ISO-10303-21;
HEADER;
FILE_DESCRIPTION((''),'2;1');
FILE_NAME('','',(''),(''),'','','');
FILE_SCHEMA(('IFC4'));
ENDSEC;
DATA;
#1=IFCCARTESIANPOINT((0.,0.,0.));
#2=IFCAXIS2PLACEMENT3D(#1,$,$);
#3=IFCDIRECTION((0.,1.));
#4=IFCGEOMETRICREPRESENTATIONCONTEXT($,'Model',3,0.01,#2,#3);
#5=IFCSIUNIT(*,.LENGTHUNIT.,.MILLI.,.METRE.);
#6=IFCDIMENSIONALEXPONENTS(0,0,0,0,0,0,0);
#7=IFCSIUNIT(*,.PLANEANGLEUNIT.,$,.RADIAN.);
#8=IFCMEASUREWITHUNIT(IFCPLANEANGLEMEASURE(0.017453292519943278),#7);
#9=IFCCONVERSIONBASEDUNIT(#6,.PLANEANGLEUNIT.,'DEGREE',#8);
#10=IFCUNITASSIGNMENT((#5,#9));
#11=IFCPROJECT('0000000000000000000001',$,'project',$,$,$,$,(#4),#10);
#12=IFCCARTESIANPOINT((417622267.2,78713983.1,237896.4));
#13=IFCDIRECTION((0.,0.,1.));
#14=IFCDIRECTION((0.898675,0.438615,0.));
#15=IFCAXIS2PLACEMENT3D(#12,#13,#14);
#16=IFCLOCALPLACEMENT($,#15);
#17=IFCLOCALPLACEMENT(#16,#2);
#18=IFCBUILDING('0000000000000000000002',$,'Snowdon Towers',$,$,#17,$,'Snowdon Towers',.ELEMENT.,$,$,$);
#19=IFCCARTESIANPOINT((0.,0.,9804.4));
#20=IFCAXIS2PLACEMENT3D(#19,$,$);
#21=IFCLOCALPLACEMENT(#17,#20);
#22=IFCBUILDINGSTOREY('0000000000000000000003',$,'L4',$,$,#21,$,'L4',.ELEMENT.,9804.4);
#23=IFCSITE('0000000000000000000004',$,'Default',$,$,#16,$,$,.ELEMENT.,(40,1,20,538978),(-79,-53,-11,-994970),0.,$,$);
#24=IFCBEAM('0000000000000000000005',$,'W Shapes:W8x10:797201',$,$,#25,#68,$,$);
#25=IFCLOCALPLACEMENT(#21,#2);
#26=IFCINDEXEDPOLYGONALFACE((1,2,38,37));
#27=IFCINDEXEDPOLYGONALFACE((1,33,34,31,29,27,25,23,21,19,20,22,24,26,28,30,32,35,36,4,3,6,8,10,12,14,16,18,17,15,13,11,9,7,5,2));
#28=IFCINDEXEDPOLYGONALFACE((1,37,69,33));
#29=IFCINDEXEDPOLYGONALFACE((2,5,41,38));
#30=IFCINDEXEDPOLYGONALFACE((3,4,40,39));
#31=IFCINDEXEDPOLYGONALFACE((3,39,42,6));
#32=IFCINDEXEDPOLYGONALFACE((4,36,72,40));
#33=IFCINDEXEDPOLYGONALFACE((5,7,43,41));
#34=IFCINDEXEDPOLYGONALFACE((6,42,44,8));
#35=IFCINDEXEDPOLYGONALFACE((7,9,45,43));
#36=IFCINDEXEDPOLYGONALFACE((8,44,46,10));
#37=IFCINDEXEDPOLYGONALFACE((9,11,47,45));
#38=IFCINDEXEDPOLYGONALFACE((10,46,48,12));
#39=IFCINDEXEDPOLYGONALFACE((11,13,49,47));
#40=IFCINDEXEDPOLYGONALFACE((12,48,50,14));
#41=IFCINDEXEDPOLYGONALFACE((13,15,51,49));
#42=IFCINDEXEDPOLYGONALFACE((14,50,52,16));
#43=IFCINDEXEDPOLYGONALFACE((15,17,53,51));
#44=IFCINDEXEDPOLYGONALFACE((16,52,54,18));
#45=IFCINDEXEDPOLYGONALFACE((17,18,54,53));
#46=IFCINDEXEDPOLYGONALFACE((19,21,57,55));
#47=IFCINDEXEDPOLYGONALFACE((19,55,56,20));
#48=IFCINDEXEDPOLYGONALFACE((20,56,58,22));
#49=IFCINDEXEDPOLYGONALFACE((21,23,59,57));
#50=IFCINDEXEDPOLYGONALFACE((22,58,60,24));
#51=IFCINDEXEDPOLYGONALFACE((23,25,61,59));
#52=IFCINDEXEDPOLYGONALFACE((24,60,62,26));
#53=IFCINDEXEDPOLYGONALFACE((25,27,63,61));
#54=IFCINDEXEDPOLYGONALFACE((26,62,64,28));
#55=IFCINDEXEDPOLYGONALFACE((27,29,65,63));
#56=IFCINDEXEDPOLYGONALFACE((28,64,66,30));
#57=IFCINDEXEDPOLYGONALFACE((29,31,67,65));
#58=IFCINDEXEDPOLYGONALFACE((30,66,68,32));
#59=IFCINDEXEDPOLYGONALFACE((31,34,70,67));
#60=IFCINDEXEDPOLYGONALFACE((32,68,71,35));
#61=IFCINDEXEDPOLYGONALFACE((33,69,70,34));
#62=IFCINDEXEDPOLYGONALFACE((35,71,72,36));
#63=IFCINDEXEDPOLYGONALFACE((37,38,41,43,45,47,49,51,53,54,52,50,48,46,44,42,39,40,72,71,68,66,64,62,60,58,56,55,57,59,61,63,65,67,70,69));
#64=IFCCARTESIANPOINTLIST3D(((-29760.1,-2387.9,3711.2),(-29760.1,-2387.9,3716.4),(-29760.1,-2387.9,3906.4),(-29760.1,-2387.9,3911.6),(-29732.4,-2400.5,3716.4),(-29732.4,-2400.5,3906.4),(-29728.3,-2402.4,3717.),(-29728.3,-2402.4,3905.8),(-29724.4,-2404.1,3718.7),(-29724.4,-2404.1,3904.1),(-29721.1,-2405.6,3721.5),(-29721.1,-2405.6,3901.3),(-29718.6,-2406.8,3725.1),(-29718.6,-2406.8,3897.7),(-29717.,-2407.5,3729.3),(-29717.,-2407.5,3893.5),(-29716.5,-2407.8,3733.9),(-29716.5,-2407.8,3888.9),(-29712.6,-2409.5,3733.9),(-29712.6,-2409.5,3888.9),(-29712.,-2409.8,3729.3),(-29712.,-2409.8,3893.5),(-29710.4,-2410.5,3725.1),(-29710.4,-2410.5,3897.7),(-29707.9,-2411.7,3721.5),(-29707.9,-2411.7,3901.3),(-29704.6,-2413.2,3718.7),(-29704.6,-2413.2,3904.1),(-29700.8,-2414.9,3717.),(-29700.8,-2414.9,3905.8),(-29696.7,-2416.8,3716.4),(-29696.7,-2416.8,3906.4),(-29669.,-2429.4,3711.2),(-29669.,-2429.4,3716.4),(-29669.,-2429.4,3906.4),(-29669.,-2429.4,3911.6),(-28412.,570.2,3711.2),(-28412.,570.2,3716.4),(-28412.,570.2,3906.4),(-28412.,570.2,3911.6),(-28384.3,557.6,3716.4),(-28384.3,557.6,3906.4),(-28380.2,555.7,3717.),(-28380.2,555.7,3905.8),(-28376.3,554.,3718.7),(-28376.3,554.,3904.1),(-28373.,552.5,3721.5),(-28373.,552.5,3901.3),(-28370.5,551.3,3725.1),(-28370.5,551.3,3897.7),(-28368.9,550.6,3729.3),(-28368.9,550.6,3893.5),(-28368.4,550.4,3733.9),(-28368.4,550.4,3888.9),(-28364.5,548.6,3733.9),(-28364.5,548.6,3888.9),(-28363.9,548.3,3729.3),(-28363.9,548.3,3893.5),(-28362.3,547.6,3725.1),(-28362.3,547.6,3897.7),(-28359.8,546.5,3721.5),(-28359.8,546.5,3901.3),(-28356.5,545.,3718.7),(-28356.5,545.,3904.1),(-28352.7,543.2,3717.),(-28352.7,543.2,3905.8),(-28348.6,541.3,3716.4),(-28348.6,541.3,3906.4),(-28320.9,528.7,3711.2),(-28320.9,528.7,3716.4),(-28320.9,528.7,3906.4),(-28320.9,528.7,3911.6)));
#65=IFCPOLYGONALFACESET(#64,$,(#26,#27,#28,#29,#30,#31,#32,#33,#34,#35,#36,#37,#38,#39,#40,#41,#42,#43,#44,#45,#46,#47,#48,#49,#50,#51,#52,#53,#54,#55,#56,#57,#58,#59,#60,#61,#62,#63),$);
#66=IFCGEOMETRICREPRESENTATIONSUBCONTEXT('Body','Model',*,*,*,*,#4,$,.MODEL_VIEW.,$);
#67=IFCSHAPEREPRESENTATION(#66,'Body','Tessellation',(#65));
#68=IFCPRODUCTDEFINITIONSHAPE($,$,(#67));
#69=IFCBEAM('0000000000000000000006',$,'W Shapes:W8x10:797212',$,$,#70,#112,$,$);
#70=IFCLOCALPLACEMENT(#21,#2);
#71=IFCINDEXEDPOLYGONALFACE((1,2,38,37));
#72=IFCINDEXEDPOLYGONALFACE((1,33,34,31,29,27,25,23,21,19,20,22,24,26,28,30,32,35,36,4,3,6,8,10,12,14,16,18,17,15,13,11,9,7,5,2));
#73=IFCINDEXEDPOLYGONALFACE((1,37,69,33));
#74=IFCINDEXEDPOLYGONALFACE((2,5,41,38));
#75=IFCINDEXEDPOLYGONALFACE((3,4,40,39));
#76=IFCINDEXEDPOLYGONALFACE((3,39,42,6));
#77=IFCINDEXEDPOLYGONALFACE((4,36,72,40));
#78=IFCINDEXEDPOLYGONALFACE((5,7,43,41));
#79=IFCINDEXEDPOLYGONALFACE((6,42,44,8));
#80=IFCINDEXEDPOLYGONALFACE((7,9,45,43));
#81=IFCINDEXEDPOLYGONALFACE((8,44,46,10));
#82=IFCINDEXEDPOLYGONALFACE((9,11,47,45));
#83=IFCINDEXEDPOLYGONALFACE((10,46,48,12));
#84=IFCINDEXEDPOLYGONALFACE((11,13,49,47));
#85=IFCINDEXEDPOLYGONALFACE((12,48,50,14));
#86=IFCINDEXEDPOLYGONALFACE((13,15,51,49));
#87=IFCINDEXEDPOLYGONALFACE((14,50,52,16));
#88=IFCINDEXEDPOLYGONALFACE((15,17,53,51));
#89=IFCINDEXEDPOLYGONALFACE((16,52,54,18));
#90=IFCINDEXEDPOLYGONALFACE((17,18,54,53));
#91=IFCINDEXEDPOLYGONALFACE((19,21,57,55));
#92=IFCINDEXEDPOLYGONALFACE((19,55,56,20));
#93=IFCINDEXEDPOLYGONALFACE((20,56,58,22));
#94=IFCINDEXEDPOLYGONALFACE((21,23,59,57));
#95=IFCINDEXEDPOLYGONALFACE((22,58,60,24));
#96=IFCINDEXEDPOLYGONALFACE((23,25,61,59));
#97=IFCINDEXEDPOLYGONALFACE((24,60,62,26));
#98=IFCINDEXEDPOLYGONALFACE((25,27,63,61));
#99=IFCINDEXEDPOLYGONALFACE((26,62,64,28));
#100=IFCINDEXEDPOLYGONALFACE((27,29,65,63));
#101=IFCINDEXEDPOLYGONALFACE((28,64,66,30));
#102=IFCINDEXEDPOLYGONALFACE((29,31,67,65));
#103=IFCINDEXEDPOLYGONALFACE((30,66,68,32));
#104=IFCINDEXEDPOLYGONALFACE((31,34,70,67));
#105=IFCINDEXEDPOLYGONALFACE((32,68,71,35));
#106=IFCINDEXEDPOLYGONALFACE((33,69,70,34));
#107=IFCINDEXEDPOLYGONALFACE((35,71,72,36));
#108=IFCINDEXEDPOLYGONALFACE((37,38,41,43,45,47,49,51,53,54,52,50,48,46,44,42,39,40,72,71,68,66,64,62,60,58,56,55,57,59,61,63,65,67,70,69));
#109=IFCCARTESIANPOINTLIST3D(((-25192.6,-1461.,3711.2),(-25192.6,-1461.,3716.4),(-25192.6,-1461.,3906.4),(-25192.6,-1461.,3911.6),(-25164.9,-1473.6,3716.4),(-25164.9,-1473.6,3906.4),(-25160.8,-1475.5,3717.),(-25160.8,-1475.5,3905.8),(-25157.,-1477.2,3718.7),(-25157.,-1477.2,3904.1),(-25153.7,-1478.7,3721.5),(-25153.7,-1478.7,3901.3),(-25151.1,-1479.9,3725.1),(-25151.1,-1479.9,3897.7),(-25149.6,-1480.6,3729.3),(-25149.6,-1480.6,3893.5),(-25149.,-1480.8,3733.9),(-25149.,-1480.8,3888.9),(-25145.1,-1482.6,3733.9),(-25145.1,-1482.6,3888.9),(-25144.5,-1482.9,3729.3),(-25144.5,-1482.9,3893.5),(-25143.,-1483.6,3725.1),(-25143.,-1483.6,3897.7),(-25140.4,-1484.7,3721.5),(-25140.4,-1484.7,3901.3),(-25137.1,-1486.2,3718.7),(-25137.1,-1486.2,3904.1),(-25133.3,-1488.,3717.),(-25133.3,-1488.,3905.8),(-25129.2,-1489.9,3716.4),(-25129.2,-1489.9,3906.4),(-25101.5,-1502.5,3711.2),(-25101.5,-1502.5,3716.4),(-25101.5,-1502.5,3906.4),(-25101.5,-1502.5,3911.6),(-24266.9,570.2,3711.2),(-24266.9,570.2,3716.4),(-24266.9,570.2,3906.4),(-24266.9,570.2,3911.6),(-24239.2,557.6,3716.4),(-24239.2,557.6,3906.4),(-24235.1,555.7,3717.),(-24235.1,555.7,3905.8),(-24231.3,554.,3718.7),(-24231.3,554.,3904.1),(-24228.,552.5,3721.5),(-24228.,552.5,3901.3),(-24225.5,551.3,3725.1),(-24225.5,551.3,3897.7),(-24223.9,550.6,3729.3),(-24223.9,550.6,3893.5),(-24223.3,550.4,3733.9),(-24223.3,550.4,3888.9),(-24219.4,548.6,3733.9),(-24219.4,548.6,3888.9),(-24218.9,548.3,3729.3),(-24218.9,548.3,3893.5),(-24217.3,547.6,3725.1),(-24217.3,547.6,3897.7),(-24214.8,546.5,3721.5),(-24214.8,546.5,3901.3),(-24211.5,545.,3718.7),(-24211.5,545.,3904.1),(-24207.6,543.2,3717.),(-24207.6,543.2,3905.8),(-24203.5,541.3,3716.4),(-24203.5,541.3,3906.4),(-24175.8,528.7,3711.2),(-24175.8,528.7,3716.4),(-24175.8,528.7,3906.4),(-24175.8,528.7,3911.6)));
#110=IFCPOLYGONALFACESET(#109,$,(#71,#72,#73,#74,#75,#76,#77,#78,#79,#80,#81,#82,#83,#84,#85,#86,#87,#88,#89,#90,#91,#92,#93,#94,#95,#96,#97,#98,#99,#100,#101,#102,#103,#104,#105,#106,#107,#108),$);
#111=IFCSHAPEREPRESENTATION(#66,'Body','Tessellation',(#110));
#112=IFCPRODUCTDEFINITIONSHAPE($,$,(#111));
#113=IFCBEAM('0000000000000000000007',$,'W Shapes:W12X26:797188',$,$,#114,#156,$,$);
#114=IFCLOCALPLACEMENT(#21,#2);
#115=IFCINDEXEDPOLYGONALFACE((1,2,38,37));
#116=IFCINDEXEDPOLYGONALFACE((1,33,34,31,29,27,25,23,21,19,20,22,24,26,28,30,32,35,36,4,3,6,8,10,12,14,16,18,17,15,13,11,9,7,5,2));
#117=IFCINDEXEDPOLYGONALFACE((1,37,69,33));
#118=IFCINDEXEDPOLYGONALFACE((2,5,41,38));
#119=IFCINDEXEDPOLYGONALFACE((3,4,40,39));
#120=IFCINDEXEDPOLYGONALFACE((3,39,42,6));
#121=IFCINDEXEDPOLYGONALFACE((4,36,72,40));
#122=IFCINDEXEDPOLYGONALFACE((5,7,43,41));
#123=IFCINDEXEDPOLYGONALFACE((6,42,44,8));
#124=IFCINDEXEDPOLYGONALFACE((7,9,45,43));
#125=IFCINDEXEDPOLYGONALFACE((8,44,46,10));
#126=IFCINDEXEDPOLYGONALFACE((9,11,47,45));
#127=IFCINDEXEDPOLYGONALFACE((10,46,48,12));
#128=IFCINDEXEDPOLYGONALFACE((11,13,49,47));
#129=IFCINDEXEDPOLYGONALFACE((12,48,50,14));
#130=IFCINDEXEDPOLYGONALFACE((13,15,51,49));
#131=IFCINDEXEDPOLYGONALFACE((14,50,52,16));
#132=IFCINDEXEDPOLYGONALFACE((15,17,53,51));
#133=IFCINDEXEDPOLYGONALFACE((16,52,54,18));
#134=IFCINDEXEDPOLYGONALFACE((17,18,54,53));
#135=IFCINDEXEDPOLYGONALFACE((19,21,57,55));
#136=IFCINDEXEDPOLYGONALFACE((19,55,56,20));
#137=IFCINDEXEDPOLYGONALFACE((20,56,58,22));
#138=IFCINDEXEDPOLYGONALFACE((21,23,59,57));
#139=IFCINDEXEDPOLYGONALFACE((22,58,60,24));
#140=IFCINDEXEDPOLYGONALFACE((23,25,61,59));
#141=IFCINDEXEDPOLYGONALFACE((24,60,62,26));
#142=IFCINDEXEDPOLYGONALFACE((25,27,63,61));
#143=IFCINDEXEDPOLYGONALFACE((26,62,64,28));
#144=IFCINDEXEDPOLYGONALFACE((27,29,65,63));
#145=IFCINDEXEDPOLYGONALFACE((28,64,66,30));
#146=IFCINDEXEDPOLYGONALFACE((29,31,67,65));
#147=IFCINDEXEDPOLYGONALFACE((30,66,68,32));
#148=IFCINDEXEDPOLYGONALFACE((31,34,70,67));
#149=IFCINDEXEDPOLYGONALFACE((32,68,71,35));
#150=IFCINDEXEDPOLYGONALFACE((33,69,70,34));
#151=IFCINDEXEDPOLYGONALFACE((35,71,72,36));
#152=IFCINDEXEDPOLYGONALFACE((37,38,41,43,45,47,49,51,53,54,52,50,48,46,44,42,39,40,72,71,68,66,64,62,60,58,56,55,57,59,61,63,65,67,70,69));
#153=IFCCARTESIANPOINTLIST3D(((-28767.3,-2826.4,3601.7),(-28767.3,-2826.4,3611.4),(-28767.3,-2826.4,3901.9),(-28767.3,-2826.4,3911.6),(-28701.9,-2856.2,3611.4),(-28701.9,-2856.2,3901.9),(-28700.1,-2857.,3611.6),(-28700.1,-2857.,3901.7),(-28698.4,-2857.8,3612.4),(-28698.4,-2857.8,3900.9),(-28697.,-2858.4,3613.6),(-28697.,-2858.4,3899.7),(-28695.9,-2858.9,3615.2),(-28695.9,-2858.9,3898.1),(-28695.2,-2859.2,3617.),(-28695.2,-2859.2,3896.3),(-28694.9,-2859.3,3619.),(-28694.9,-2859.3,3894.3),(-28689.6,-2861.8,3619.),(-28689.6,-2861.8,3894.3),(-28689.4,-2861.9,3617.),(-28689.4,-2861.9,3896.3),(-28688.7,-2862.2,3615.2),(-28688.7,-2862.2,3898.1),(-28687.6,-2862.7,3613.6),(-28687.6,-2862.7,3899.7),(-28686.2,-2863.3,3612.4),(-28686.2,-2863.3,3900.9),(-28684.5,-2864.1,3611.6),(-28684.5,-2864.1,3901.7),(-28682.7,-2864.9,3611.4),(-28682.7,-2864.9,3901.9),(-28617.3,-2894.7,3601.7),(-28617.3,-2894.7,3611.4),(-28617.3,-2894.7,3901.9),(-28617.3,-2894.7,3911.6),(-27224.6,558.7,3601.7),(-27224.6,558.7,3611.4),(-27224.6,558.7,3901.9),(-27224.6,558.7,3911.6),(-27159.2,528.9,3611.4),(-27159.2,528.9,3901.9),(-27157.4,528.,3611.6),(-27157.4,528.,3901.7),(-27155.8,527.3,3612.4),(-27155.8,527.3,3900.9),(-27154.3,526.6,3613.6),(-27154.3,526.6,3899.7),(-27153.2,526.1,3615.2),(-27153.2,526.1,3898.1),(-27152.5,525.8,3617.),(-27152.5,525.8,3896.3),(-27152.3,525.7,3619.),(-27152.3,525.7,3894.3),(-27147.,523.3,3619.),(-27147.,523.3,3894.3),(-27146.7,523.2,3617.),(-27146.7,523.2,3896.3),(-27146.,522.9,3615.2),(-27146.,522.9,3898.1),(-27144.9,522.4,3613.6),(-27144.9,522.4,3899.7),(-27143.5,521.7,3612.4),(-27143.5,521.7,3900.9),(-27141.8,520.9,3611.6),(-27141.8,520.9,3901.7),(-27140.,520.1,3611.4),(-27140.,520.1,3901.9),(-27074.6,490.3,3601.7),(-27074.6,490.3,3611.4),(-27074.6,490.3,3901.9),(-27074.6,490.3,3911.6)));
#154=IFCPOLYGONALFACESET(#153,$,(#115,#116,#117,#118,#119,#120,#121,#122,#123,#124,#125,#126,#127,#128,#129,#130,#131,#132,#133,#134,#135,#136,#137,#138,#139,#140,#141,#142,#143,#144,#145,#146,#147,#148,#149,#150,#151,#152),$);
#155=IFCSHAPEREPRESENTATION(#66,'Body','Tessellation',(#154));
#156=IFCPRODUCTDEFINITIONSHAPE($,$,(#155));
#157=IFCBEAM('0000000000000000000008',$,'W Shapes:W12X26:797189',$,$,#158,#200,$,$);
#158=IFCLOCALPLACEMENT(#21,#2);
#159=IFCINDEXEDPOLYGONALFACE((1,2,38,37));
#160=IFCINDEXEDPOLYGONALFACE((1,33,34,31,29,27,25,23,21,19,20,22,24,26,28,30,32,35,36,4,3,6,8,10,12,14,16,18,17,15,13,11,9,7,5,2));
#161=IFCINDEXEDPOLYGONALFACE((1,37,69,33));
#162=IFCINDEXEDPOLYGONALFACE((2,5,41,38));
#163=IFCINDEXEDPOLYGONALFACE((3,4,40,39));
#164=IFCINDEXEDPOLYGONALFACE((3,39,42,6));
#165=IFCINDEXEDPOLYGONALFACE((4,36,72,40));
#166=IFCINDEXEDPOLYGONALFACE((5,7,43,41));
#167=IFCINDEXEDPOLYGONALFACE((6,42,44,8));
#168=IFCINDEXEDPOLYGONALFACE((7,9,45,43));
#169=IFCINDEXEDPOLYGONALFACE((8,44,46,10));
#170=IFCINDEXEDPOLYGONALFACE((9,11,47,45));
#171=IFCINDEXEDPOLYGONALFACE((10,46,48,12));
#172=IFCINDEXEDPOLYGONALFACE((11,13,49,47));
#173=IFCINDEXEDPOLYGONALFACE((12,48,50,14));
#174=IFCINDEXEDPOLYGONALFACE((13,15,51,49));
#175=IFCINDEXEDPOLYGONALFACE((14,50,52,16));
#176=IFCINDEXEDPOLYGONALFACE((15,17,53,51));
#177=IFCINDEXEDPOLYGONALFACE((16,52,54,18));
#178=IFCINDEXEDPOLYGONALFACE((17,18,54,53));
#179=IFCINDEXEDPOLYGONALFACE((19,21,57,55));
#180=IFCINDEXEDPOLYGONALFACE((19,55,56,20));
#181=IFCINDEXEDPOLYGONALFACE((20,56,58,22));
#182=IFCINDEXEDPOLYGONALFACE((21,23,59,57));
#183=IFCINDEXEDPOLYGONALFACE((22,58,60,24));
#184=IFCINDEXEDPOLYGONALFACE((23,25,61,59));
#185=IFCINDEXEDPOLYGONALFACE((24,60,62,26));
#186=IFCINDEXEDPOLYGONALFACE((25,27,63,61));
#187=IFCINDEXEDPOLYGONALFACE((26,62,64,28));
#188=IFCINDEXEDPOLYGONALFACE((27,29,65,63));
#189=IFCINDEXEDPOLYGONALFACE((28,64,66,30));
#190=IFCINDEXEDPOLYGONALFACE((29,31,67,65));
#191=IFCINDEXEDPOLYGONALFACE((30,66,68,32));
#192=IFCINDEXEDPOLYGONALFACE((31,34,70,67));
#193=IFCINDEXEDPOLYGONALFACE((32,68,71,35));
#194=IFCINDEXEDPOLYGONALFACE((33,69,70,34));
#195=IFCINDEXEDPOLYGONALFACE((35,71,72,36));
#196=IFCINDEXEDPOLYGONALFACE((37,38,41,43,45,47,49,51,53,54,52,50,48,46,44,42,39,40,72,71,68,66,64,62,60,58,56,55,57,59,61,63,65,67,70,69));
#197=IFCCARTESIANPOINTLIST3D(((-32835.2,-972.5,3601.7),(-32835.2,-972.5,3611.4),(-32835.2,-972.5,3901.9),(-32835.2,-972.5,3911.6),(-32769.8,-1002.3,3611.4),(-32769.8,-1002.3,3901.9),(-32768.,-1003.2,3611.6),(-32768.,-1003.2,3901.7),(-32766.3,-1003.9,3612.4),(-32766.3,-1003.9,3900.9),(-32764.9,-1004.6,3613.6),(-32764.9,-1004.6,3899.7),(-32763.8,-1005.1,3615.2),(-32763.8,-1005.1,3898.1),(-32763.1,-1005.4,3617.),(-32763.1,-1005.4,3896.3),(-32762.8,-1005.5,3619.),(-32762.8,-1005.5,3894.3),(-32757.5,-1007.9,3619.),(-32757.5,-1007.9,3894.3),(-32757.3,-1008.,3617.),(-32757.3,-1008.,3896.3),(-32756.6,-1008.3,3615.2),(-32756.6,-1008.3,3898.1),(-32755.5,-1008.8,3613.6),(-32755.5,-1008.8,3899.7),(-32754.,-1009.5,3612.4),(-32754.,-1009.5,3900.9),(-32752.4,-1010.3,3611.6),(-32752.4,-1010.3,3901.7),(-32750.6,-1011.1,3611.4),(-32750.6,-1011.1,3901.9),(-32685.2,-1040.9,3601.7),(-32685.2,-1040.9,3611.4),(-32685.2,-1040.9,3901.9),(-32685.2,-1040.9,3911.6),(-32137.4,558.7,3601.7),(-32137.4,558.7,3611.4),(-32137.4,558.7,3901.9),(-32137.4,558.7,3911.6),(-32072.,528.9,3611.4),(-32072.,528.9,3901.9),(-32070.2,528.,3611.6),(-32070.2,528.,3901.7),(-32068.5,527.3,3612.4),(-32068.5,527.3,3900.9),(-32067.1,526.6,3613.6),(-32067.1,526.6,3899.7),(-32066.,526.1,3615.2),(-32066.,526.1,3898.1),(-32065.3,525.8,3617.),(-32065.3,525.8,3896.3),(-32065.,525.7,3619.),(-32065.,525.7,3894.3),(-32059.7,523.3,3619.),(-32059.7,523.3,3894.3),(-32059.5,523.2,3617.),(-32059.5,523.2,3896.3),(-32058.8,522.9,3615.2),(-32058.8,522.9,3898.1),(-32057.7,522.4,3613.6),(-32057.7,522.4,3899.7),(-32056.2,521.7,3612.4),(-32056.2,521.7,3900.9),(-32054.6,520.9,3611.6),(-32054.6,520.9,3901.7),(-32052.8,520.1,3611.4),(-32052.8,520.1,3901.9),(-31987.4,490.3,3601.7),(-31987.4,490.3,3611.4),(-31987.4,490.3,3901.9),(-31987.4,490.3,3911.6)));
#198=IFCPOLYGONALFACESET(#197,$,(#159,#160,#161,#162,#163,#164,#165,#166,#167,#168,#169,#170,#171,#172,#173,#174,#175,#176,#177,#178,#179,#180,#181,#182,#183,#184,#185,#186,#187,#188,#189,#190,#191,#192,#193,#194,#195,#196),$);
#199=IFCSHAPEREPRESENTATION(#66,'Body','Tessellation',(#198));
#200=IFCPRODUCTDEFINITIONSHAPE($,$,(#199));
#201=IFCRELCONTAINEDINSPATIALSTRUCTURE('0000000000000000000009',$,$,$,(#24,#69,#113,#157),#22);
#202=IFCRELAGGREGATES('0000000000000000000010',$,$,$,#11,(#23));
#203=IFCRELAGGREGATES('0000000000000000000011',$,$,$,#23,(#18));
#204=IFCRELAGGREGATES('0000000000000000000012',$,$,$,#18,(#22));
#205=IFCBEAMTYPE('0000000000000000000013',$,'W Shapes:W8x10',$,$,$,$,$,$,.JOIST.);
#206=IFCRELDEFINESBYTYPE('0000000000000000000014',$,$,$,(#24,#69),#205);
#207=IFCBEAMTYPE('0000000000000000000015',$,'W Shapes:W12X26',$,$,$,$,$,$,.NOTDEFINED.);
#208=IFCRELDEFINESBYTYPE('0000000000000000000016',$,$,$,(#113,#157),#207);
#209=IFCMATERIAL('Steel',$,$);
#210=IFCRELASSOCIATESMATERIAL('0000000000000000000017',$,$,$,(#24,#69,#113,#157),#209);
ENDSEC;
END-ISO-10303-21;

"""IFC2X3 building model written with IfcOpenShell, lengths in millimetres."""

from ifc_helpers import new_model, entity, si_unit, converted_unit, direction, frame, frame_2d, origin, place, context, subcontext, project, spatial, i_section, extrude, material, type_object, element, save


model = new_model("IFC2X3")

# Units and contexts
model_context = context("Model", 3, precision=0.01, world=origin(), true_north=direction((0.0, 1.0)))
body_context = subcontext(model_context, "Body", "Model", "MODEL_VIEW")
ifc_project = project(units=[si_unit("LENGTHUNIT", "METRE", prefix="MILLI"), converted_unit("PLANEANGLEUNIT", "DEGREE", entity("IfcPlaneAngleMeasure", 0.017453292519943278), si_unit("PLANEANGLEUNIT", "RADIAN"), dimensions=[0, 0, 0, 0, 0, 0, 0])], contexts=[model_context])

# Site, building, storey
site_placement = place(None, frame((417622267.2, 78713983.1, 237896.4), z_axis=(0.0, 0.0, 1.0), x_axis=(0.898675, 0.438615, 0.0)))
site = spatial("IfcSite", under=ifc_project, at=site_placement, Name="Default", CompositionType="ELEMENT", RefLatitude=(40, 1, 20, 538978), RefLongitude=(-79, -53, -11, -994970), RefElevation=0.0)
building_placement = place(site_placement, origin())
building = spatial("IfcBuilding", under=site, at=building_placement, Name="Snowdon Towers", LongName="Snowdon Towers", CompositionType="ELEMENT")
storey_placement = place(building_placement, frame((0.0, 0.0, 9804.4)))
storey = spatial("IfcBuildingStorey", under=building, at=storey_placement, Name="L4", LongName="L4", CompositionType="ELEMENT", Elevation=9804.4)

# Shared definitions
ifc_material_1 = material(Name="Steel")

# Beams
beam_type_1 = type_object("IfcBeamType", Name="W Shapes:W8x10", PredefinedType="JOIST")
beam_1_placement = place(storey_placement, frame((-29748.7, -2483.6, 3911.6), z_axis=(0.0, 0.0, 1.0), x_axis=(0.414693, 0.909961, 0.0)))
element("IfcBeam", 1, at=beam_1_placement, inside=storey, type_object=beam_type_1, material=ifc_material_1, Name="W Shapes:W8x10:797201", context=body_context, shape_type="SweptSolid", body=[
    extrude(i_section(OverallWidth=100.1, OverallDepth=200.4, WebThickness=4.3, FlangeThickness=5.2, FilletRadius=17.5, at=frame_2d((0.0, 0.0), x_axis=(0.0, 1.0))), frame((82.4, 0.0, -100.2), z_axis=(1.0, 0.0, 0.0), x_axis=(0.0, 0.0, -1.0)), (0.0, 0.0, 1.0), 3250.8),
])
beam_2_placement = place(storey_placement, frame((-25181.2, -1556.7, 3911.6), z_axis=(0.0, 0.0, 1.0), x_axis=(0.414693, 0.909961, 0.0)))
element("IfcBeam", 2, at=beam_2_placement, inside=storey, type_object=beam_type_1, material=ifc_material_1, Name="W Shapes:W8x10:797212", context=body_context, shape_type="SweptSolid", body=[
    extrude(i_section(OverallWidth=100.1, OverallDepth=200.4, WebThickness=4.3, FlangeThickness=5.2, FilletRadius=17.5, at=frame_2d((0.0, 0.0), x_axis=(0.0, 1.0))), frame((82.4, 0.0, -100.2), z_axis=(1.0, 0.0, 0.0), x_axis=(0.0, 0.0, -1.0)), (0.0, 0.0, 1.0), 2232.2),
])
beam_type_2 = type_object("IfcBeamType", Name="W Shapes:W12X26", PredefinedType="NOTDEFINED")
beam_3_placement = place(storey_placement, frame((-28731.7, -2947.1, 3911.6), z_axis=(0.0, 0.0, 1.0), x_axis=(0.414693, 0.909961, 0.0)))
element("IfcBeam", 3, at=beam_3_placement, inside=storey, type_object=beam_type_2, material=ifc_material_1, Name="W Shapes:W12X26:797188", context=body_context, shape_type="SweptSolid", body=[
    extrude(i_section(OverallWidth=164.8, OverallDepth=309.9, WebThickness=5.8, FlangeThickness=9.7, FilletRadius=7.6, at=frame_2d((0.0, 0.0), x_axis=(0.0, 1.0))), frame((95.1, 0.0, -154.9), z_axis=(1.0, 0.0, 0.0), x_axis=(0.0, 0.0, -1.0)), (0.0, 0.0, 1.0), 3720.0),
])
beam_4_placement = place(storey_placement, frame((-32799.6, -1093.3, 3911.6), z_axis=(0.0, 0.0, 1.0), x_axis=(0.414693, 0.909961, 0.0)))
element("IfcBeam", 4, at=beam_4_placement, inside=storey, type_object=beam_type_2, material=ifc_material_1, Name="W Shapes:W12X26:797189", context=body_context, shape_type="SweptSolid", body=[
    extrude(i_section(OverallWidth=164.8, OverallDepth=309.9, WebThickness=5.8, FlangeThickness=9.7, FilletRadius=7.6, at=frame_2d((0.0, 0.0), x_axis=(0.0, 1.0))), frame((95.1, 0.0, -154.9), z_axis=(1.0, 0.0, 0.0), x_axis=(0.0, 0.0, -1.0)), (0.0, 0.0, 1.0), 1682.7),
])

save(model, "model.ifc")
